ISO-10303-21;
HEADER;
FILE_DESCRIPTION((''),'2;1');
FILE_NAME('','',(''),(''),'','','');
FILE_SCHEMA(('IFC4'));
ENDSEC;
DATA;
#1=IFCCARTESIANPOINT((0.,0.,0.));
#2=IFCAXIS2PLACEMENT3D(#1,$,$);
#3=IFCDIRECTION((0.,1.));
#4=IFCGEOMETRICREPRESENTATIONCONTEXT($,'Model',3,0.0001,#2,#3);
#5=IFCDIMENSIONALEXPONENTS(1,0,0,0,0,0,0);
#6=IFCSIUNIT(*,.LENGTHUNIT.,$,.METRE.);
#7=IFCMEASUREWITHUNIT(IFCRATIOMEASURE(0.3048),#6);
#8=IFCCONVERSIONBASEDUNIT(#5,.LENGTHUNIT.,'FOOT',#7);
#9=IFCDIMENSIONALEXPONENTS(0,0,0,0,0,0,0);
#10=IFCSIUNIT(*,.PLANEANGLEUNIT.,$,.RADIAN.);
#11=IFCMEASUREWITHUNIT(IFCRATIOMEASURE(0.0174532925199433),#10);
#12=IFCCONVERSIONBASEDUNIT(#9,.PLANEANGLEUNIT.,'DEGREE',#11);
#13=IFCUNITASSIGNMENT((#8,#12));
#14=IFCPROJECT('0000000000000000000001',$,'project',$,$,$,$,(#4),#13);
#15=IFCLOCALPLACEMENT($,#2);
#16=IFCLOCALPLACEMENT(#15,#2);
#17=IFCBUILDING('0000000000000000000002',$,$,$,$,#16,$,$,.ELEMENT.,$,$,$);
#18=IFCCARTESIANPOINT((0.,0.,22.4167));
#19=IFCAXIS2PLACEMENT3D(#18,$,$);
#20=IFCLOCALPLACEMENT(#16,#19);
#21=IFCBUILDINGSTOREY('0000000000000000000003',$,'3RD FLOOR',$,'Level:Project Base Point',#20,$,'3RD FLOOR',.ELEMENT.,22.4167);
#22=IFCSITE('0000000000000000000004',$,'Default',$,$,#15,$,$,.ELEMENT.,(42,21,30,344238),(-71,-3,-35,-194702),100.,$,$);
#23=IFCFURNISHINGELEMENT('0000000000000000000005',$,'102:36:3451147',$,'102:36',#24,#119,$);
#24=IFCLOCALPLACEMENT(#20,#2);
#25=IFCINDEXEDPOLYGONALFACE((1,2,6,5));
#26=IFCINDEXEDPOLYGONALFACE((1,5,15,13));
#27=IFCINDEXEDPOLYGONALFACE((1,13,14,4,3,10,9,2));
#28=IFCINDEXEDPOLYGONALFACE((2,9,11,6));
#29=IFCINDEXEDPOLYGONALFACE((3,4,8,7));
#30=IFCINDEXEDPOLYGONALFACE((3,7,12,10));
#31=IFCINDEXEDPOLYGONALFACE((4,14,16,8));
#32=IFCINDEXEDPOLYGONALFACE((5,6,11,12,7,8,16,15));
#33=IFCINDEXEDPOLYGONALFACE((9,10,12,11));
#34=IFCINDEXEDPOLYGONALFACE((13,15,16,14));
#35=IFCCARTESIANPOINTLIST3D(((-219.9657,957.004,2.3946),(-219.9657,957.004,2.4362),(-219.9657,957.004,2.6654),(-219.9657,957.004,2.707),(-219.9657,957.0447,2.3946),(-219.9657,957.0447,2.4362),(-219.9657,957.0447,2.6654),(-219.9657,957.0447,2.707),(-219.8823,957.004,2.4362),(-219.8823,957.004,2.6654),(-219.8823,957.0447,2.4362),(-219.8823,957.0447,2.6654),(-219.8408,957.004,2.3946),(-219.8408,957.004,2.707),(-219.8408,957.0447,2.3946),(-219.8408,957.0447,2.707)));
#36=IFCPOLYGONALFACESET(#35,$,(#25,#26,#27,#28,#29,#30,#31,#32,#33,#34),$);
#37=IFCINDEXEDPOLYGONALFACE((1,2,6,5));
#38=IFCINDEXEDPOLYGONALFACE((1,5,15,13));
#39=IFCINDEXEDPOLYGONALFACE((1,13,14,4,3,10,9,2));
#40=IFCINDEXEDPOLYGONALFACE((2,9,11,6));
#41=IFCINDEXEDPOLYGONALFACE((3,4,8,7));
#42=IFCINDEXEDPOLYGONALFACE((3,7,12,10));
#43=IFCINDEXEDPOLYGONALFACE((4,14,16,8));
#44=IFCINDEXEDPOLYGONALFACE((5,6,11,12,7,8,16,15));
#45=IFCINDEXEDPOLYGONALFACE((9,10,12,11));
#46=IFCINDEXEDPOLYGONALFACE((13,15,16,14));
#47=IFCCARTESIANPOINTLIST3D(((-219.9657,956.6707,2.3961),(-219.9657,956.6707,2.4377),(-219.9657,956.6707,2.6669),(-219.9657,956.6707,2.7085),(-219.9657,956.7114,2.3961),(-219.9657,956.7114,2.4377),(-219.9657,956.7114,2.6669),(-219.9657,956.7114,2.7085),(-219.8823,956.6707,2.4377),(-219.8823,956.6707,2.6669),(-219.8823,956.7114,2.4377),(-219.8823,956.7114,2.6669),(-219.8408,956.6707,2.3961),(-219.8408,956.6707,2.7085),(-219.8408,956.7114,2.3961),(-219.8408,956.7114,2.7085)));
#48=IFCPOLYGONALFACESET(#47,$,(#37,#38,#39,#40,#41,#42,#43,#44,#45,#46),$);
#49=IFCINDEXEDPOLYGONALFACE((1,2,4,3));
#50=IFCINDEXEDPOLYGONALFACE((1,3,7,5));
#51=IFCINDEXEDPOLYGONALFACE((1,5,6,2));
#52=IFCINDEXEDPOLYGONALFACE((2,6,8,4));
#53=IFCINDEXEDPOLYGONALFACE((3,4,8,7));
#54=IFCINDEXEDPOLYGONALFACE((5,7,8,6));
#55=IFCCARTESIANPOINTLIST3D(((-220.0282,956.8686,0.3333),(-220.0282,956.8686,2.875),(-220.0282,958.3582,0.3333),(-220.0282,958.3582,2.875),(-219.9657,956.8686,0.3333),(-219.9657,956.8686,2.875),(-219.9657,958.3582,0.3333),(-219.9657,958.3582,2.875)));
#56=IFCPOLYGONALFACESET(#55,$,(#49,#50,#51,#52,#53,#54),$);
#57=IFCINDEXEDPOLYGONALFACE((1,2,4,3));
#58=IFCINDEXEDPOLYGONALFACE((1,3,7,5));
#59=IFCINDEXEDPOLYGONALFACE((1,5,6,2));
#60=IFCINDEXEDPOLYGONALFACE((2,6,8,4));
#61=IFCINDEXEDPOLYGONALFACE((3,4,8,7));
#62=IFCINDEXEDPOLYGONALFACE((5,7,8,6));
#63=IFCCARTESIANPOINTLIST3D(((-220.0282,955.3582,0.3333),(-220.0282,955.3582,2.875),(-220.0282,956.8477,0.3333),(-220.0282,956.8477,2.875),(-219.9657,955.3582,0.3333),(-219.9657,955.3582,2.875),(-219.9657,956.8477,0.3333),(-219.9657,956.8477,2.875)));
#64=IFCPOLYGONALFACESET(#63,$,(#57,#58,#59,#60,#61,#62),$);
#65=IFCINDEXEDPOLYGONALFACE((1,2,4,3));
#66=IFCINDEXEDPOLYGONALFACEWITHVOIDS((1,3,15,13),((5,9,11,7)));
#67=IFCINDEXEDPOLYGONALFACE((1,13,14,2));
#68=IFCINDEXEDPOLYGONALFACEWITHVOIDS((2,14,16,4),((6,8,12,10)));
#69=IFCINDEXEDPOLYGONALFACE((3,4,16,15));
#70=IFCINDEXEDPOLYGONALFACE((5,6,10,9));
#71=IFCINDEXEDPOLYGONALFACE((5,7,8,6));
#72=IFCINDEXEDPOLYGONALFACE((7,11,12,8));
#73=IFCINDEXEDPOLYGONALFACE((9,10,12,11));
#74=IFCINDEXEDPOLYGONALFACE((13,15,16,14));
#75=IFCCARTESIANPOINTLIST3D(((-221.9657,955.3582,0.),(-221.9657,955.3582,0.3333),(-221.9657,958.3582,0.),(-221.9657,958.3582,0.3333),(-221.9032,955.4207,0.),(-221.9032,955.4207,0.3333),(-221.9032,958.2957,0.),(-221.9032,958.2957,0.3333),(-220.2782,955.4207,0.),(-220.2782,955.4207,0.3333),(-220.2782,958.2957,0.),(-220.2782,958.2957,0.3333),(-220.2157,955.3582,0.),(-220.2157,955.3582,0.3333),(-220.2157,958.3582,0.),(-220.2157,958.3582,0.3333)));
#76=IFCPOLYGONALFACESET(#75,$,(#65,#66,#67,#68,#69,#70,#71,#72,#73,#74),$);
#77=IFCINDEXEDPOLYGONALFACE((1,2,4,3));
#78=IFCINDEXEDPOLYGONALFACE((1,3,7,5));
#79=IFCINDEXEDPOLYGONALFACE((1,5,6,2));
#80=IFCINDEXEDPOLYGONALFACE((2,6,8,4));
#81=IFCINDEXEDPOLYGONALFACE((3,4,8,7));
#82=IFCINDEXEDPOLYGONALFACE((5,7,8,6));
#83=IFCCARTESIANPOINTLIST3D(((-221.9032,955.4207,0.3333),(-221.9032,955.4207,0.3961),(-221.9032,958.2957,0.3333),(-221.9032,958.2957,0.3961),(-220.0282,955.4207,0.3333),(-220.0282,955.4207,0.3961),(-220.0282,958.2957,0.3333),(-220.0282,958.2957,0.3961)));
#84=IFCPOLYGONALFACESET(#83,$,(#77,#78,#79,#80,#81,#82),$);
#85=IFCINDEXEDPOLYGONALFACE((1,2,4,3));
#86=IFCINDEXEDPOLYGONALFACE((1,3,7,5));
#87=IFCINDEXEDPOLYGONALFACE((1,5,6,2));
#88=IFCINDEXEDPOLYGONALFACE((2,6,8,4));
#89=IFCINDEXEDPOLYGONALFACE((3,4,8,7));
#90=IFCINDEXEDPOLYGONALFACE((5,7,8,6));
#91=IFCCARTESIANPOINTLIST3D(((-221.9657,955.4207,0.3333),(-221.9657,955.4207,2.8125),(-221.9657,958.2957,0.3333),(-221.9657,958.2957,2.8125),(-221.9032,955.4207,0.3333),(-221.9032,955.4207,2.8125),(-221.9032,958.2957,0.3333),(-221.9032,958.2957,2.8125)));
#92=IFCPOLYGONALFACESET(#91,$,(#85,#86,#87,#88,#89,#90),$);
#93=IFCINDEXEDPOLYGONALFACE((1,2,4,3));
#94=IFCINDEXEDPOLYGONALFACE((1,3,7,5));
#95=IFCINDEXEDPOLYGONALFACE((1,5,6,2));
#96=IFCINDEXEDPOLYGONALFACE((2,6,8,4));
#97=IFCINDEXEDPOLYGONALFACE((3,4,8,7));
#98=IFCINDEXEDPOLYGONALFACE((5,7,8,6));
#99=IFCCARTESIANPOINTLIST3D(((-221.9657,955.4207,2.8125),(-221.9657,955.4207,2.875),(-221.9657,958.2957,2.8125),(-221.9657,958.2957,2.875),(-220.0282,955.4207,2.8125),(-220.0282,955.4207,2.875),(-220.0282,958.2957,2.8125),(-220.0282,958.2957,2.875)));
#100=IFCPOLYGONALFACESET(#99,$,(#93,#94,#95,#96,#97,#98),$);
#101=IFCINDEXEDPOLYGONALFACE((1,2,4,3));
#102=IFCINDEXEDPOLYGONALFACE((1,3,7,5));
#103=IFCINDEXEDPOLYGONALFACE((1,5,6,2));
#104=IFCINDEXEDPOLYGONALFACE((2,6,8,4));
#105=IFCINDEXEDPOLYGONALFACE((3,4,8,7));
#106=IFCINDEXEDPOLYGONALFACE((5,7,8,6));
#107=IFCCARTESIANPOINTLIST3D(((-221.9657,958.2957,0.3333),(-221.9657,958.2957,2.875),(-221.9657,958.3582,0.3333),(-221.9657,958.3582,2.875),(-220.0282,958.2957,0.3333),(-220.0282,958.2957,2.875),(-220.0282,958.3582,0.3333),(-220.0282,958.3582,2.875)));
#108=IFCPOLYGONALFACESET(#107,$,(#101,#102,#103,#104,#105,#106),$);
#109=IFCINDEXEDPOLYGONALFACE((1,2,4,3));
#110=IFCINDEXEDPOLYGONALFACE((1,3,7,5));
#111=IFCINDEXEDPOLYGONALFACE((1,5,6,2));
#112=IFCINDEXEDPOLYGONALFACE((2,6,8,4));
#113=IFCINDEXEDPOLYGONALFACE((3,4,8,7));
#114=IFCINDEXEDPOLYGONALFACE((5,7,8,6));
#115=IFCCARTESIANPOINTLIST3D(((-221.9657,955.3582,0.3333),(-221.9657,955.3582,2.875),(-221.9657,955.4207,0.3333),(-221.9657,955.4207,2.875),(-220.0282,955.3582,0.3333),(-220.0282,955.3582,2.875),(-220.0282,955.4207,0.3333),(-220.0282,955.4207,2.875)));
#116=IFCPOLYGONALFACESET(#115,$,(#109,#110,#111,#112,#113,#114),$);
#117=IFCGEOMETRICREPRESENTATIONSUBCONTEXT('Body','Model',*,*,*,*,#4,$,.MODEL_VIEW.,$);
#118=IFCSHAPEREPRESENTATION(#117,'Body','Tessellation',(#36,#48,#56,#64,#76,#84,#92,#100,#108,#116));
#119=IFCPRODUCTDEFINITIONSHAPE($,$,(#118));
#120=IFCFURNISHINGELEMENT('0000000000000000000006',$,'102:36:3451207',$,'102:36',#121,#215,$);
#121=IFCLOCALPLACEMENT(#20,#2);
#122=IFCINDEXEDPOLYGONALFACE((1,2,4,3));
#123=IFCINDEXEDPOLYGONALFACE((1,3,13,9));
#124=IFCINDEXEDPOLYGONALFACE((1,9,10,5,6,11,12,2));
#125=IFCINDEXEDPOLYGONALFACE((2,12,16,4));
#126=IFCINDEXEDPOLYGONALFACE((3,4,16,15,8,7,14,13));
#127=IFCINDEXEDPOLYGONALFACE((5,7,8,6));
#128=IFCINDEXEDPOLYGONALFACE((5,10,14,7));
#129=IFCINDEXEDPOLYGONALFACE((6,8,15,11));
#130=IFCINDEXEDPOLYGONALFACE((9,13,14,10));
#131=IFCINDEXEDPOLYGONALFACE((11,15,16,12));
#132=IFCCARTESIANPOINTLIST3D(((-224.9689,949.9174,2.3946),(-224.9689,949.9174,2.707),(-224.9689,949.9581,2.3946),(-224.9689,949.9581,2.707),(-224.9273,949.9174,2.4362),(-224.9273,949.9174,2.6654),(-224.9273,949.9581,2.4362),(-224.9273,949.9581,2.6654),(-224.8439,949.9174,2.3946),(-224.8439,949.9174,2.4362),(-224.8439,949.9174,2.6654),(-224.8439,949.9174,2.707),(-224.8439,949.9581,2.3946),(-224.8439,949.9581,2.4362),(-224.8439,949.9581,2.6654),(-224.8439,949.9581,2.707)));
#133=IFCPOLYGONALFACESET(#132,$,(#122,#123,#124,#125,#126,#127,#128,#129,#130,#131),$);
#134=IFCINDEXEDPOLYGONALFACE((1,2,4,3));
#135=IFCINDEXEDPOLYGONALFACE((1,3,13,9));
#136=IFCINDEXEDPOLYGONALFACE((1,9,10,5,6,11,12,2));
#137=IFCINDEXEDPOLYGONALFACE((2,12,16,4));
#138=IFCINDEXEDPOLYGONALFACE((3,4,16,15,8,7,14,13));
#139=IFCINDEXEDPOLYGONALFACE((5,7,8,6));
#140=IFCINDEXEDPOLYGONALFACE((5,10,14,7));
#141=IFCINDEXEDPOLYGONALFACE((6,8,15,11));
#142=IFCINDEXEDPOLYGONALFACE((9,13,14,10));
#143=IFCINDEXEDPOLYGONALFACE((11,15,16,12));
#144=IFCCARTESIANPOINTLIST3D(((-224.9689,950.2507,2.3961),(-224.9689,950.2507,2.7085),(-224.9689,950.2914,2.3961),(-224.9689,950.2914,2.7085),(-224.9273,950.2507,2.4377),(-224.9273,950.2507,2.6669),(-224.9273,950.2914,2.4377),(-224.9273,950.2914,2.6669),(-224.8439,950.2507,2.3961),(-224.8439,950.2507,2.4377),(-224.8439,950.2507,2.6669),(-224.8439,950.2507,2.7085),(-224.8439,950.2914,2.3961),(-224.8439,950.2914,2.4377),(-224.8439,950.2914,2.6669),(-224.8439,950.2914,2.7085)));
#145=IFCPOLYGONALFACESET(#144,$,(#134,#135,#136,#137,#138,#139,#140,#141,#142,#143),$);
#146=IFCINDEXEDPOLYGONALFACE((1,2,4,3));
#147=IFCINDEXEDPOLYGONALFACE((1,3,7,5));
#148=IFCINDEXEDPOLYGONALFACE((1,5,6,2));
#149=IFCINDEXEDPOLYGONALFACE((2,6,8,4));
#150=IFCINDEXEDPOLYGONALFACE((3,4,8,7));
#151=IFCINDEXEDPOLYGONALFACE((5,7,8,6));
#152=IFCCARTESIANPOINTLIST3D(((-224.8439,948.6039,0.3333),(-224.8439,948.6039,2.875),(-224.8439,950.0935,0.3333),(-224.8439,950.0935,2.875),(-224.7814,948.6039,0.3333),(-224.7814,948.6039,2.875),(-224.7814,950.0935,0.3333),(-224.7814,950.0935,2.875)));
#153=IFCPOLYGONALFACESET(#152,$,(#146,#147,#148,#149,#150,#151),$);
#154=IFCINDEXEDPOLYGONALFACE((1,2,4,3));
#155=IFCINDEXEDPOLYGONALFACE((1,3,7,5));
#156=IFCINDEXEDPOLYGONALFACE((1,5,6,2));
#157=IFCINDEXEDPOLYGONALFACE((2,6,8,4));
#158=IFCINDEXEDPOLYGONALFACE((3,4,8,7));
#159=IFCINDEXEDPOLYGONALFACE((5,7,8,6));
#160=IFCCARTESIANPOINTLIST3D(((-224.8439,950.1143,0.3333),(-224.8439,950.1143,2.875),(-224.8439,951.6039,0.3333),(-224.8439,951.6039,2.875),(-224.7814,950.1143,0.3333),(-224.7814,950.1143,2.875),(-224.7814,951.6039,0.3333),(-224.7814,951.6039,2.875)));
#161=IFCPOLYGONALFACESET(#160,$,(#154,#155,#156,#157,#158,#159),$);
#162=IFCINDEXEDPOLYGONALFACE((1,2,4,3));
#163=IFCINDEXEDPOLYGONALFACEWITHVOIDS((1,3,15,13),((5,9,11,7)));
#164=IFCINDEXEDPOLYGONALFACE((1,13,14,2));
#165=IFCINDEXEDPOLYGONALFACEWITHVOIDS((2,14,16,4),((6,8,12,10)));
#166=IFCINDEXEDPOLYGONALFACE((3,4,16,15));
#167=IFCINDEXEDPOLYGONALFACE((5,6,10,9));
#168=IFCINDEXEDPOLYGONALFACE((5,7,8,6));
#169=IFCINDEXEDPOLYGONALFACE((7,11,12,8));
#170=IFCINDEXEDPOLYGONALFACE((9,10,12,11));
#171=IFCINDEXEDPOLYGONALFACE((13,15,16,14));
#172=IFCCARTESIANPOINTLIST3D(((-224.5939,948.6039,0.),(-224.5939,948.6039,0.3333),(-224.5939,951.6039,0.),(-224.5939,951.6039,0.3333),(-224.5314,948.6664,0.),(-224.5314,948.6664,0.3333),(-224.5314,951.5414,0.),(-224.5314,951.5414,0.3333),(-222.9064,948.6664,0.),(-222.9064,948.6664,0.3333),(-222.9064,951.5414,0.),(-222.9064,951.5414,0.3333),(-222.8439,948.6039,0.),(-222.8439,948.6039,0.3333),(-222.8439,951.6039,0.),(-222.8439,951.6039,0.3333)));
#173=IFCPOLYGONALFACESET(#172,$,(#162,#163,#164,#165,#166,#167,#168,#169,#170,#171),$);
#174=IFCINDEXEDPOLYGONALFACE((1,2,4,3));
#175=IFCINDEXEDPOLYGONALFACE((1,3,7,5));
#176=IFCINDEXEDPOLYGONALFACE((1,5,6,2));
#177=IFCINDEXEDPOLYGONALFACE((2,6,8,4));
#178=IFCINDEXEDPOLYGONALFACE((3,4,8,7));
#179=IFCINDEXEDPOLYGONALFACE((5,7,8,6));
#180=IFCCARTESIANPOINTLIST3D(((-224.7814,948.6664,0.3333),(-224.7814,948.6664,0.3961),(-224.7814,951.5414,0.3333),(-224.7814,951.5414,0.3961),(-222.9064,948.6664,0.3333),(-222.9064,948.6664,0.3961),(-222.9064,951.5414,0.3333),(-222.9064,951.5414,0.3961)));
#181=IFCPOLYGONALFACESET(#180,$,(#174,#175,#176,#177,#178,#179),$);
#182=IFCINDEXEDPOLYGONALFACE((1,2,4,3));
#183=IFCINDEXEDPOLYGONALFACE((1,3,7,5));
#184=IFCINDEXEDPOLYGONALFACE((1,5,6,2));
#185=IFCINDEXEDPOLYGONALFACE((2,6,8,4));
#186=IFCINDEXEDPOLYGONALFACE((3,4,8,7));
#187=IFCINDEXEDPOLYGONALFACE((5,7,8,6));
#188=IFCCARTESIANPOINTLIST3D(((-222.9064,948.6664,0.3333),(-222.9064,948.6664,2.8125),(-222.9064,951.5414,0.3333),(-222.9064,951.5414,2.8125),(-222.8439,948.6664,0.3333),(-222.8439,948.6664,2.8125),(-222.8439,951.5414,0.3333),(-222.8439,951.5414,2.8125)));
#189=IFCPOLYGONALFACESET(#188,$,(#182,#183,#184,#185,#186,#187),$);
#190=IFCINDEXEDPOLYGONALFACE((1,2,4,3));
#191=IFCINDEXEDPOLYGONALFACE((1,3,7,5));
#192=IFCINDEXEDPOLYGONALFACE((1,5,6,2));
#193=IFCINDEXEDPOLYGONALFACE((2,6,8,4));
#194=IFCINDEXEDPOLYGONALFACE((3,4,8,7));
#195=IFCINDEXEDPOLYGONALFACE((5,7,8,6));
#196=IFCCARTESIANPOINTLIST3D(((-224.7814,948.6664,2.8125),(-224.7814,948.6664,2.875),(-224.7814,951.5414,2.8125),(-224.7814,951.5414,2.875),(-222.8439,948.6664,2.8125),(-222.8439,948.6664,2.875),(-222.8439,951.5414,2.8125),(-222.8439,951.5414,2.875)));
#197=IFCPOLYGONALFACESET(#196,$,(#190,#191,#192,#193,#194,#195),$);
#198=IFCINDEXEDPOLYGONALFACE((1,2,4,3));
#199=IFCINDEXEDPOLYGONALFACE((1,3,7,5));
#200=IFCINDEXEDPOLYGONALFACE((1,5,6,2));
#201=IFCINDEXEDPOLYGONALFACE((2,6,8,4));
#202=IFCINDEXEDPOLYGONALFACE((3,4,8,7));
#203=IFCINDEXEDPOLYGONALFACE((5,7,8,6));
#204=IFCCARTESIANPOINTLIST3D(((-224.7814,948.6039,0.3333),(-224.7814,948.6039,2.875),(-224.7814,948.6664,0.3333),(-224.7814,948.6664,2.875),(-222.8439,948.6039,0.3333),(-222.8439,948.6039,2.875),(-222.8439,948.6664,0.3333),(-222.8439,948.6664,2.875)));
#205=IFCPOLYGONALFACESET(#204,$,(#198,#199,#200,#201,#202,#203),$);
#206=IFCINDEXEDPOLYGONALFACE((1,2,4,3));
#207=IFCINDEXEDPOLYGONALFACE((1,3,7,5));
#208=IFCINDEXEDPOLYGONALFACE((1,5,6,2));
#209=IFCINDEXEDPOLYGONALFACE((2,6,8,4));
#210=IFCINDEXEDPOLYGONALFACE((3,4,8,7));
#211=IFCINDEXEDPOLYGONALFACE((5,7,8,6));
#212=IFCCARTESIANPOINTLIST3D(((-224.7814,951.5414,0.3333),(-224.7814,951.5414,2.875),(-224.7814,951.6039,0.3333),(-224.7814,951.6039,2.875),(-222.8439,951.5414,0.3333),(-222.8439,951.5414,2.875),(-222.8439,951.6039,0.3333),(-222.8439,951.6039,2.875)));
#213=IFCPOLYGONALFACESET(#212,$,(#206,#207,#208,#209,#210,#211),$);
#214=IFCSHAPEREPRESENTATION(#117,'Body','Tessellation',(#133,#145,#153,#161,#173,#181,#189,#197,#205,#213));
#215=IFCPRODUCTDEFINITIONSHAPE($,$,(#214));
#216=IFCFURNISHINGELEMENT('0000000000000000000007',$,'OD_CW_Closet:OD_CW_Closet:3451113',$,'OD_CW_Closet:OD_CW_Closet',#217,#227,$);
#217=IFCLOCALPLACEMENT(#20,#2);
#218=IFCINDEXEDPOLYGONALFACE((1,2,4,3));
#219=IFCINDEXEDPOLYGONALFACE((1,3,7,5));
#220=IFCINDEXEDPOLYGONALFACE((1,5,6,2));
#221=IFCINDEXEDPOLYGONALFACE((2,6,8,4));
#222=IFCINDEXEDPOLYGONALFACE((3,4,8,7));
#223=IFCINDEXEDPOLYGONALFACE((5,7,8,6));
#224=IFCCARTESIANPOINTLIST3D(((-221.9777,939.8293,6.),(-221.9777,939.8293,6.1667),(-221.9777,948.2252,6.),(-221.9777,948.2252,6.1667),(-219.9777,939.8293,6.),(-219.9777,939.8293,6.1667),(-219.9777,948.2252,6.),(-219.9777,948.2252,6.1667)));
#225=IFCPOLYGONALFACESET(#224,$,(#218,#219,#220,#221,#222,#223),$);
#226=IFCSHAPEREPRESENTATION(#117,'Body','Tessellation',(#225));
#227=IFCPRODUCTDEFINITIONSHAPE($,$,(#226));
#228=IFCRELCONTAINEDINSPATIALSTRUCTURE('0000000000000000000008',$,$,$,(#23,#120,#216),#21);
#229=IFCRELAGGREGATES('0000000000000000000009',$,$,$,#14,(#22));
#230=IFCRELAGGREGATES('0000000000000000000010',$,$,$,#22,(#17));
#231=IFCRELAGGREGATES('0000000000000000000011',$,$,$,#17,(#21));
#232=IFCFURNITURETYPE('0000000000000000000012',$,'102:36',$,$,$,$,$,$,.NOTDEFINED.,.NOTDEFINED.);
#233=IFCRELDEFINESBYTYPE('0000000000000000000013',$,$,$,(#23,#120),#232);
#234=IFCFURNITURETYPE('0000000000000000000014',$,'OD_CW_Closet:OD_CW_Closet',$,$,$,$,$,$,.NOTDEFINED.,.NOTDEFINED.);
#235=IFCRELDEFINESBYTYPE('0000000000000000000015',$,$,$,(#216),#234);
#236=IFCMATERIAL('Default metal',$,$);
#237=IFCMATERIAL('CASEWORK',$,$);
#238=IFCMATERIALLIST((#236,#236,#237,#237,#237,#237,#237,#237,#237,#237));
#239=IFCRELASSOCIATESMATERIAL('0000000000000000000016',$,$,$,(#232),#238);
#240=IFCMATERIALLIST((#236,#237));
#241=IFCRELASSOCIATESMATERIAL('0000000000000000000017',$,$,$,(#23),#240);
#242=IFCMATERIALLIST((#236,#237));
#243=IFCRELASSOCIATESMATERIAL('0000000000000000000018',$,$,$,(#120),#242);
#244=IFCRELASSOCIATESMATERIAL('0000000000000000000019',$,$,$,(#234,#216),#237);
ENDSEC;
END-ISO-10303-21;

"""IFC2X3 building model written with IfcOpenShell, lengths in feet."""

from ifc_helpers import new_model, entity, si_unit, converted_unit, direction, frame, frame_2d, origin, origin_2d_with_axis, place, context, subcontext, project, spatial, polyline, rectangle, outline, extrude, source, transform, mapped, material, material_list, type_object, type_shapes, element, save


model = new_model("IFC2X3")

# Units and contexts
model_context = context("Model", 3, precision=0.0001, world=origin(), true_north=direction((0.0, 1.0)))
body_context = subcontext(model_context, "Body", "Model", "MODEL_VIEW")
ifc_project = project(units=[converted_unit("LENGTHUNIT", "FOOT", entity("IfcRatioMeasure", 0.3048), si_unit("LENGTHUNIT", "METRE"), dimensions=[1, 0, 0, 0, 0, 0, 0]), converted_unit("PLANEANGLEUNIT", "DEGREE", entity("IfcRatioMeasure", 0.0174532925199433), si_unit("PLANEANGLEUNIT", "RADIAN"), dimensions=[0, 0, 0, 0, 0, 0, 0])], contexts=[model_context])

# Site, building, storey
site_placement = place(None, origin())
site = spatial("IfcSite", under=ifc_project, at=site_placement, Name="Default", CompositionType="ELEMENT", RefLatitude=(42, 21, 30, 344238), RefLongitude=(-71, -3, -35, -194702), RefElevation=100.0)
building_placement = place(site_placement, origin())
building = spatial("IfcBuilding", under=site, at=building_placement, CompositionType="ELEMENT")
storey_placement = place(building_placement, frame((0.0, 0.0, 22.4167)))
storey = spatial("IfcBuildingStorey", under=building, at=storey_placement, Name="3RD FLOOR", ObjectType="Level:Project Base Point", LongName="3RD FLOOR", CompositionType="ELEMENT", Elevation=22.4167)

# Furnishing elements
ifc_material_1 = material(Name="Default metal")
ifc_material_2 = material(Name="CASEWORK")
ifc_material_list_1 = material_list([ifc_material_1, ifc_material_2])
ifc_material_list_2 = material_list([ifc_material_1, ifc_material_1, ifc_material_2, ifc_material_2, ifc_material_2, ifc_material_2, ifc_material_2, ifc_material_2, ifc_material_2, ifc_material_2])
furniture_type_1 = type_object("IfcFurnitureType", Name="102:36", material=ifc_material_list_2)
shared_shape_1 = source(origin(), body_context, "Body", "SweptSolid", [
    extrude(outline(polyline([(0.1146, -0.0521), (0.1562, -0.0521), (0.1562, 0.0729), (-0.1562, 0.0729), (-0.1562, -0.0521), (-0.1146, -0.0521), (-0.1146, 0.0313), (0.1146, 0.0313), (0.1146, -0.0521)])), frame((0.2073, -2.0521, 2.5508), z_axis=(1.0, 0.0, 0.0), x_axis=(0.0, 0.0, 1.0)), (0.0, 0.0, 1.0), 0.0407),
    extrude(outline(polyline([(0.1146, -0.0521), (0.1562, -0.0521), (0.1562, 0.0729), (-0.1562, 0.0729), (-0.1562, -0.0521), (-0.1146, -0.0521), (-0.1146, 0.0313), (0.1146, 0.0313), (0.1146, -0.0521)])), frame((-0.126, -2.0521, 2.5523), z_axis=(1.0, 0.0, 0.0), x_axis=(0.0, 0.0, 1.0)), (0.0, 0.0, 1.0), 0.0407),
    extrude(rectangle(XDim=0.0625, YDim=1.4896, at=frame_2d((0.0, 0.0), x_axis=(1.0, 0.0))), frame((0.8167, -1.9688, 0.3333), z_axis=(0.0, 0.0, 1.0), x_axis=(0.0, 1.0, 0.0)), (0.0, 0.0, 1.0), 2.5417),
    extrude(rectangle(XDim=0.0625, YDim=1.4896, at=origin_2d_with_axis()), frame((-0.6937, -1.9688, 0.3333), z_axis=(0.0, 0.0, 1.0), x_axis=(0.0, 1.0, 0.0)), (0.0, 0.0, 1.0), 2.5417),
    extrude(outline(polyline([(-1.5, -0.875), (1.5, -0.875), (1.5, 0.875), (-1.5, 0.875), (-1.5, -0.875)]), holes=[polyline([(-1.4375, -0.8125), (-1.4375, 0.8125), (1.4375, 0.8125), (1.4375, -0.8125), (-1.4375, -0.8125)])]), frame((0.0615, -0.875, 0.0)), (0.0, 0.0, 1.0), 0.3333),
    extrude(rectangle(XDim=2.875, YDim=1.875, at=origin_2d_with_axis()), frame((0.0615, -1.0, 0.3333), z_axis=(0.0, 0.0, 1.0), x_axis=(-1.0, 0.0, 0.0)), (0.0, 0.0, 1.0), 0.0627),
    extrude(rectangle(XDim=0.0625, YDim=2.875, at=origin_2d_with_axis()), frame((0.0615, -0.0312, 0.3333), z_axis=(0.0, 0.0, 1.0), x_axis=(0.0, 1.0, 0.0)), (0.0, 0.0, 1.0), 2.4792),
    extrude(rectangle(XDim=2.875, YDim=1.9375, at=origin_2d_with_axis()), frame((0.0615, -0.9688, 2.8125), z_axis=(0.0, 0.0, 1.0), x_axis=(-1.0, 0.0, 0.0)), (0.0, 0.0, 1.0), 0.0625),
    extrude(rectangle(XDim=0.0625, YDim=1.9375, at=frame_2d((0.0, 0.0), x_axis=(1.0, 0.0))), frame((1.5302, -0.9687, 0.3333)), (0.0, 0.0, 1.0), 2.5417),
    extrude(rectangle(XDim=0.0625, YDim=1.9375, at=frame_2d((0.0, 0.0), x_axis=(1.0, 0.0))), frame((-1.4073, -0.9687, 0.3333)), (0.0, 0.0, 1.0), 2.5417),
])
type_shapes(furniture_type_1, [shared_shape_1])
furnishing_1_placement = place(storey_placement, frame((-221.9657, 956.7967, 0.0), z_axis=(0.0, 0.0, 1.0), x_axis=(0.0, 1.0, 0.0)))
element("IfcFurnishingElement", 1, at=furnishing_1_placement, inside=storey, type_object=furniture_type_1, material=ifc_material_list_1, Name="102:36:3451147", ObjectType="102:36", context=body_context, shape_type="MappedRepresentation", body=[
    mapped(shared_shape_1, transform((0.0, 0.0, 0.0), scale=1.0)),
])
ifc_material_list_3 = material_list([ifc_material_1, ifc_material_2])
furnishing_2_placement = place(storey_placement, frame((-222.8439, 950.1654, 0.0), z_axis=(0.0, 0.0, 1.0), x_axis=(0.0, -1.0, 0.0)))
element("IfcFurnishingElement", 2, at=furnishing_2_placement, inside=storey, type_object=furniture_type_1, material=ifc_material_list_3, Name="102:36:3451207", ObjectType="102:36", context=body_context, shape_type="MappedRepresentation", body=[
    mapped(shared_shape_1, transform((0.0, 0.0, 0.0), scale=1.0)),
])
furniture_type_2 = type_object("IfcFurnitureType", Name="OD_CW_Closet:OD_CW_Closet", material=ifc_material_2)
shared_shape_2 = source(origin(), body_context, "Body", "SweptSolid", [
    extrude(rectangle(XDim=8.3958, YDim=2.0, at=frame_2d((0.0, 0.0), x_axis=(1.0, 0.0))), frame((4.1979, 1.0, 0.0)), (0.0, 0.0, 1.0), 0.1667),
])
type_shapes(furniture_type_2, [shared_shape_2])
furnishing_3_placement = place(storey_placement, frame((-221.9777, 948.2252, 6.0), z_axis=(0.0, 0.0, 1.0), x_axis=(0.0, -1.0, 0.0)))
element("IfcFurnishingElement", 3, at=furnishing_3_placement, inside=storey, type_object=furniture_type_2, material=ifc_material_2, Name="OD_CW_Closet:OD_CW_Closet:3451113", ObjectType="OD_CW_Closet:OD_CW_Closet", context=body_context, shape_type="MappedRepresentation", body=[
    mapped(shared_shape_2, transform((0.0, 0.0, 0.0), scale=1.0)),
])

save(model, "model.ifc")
